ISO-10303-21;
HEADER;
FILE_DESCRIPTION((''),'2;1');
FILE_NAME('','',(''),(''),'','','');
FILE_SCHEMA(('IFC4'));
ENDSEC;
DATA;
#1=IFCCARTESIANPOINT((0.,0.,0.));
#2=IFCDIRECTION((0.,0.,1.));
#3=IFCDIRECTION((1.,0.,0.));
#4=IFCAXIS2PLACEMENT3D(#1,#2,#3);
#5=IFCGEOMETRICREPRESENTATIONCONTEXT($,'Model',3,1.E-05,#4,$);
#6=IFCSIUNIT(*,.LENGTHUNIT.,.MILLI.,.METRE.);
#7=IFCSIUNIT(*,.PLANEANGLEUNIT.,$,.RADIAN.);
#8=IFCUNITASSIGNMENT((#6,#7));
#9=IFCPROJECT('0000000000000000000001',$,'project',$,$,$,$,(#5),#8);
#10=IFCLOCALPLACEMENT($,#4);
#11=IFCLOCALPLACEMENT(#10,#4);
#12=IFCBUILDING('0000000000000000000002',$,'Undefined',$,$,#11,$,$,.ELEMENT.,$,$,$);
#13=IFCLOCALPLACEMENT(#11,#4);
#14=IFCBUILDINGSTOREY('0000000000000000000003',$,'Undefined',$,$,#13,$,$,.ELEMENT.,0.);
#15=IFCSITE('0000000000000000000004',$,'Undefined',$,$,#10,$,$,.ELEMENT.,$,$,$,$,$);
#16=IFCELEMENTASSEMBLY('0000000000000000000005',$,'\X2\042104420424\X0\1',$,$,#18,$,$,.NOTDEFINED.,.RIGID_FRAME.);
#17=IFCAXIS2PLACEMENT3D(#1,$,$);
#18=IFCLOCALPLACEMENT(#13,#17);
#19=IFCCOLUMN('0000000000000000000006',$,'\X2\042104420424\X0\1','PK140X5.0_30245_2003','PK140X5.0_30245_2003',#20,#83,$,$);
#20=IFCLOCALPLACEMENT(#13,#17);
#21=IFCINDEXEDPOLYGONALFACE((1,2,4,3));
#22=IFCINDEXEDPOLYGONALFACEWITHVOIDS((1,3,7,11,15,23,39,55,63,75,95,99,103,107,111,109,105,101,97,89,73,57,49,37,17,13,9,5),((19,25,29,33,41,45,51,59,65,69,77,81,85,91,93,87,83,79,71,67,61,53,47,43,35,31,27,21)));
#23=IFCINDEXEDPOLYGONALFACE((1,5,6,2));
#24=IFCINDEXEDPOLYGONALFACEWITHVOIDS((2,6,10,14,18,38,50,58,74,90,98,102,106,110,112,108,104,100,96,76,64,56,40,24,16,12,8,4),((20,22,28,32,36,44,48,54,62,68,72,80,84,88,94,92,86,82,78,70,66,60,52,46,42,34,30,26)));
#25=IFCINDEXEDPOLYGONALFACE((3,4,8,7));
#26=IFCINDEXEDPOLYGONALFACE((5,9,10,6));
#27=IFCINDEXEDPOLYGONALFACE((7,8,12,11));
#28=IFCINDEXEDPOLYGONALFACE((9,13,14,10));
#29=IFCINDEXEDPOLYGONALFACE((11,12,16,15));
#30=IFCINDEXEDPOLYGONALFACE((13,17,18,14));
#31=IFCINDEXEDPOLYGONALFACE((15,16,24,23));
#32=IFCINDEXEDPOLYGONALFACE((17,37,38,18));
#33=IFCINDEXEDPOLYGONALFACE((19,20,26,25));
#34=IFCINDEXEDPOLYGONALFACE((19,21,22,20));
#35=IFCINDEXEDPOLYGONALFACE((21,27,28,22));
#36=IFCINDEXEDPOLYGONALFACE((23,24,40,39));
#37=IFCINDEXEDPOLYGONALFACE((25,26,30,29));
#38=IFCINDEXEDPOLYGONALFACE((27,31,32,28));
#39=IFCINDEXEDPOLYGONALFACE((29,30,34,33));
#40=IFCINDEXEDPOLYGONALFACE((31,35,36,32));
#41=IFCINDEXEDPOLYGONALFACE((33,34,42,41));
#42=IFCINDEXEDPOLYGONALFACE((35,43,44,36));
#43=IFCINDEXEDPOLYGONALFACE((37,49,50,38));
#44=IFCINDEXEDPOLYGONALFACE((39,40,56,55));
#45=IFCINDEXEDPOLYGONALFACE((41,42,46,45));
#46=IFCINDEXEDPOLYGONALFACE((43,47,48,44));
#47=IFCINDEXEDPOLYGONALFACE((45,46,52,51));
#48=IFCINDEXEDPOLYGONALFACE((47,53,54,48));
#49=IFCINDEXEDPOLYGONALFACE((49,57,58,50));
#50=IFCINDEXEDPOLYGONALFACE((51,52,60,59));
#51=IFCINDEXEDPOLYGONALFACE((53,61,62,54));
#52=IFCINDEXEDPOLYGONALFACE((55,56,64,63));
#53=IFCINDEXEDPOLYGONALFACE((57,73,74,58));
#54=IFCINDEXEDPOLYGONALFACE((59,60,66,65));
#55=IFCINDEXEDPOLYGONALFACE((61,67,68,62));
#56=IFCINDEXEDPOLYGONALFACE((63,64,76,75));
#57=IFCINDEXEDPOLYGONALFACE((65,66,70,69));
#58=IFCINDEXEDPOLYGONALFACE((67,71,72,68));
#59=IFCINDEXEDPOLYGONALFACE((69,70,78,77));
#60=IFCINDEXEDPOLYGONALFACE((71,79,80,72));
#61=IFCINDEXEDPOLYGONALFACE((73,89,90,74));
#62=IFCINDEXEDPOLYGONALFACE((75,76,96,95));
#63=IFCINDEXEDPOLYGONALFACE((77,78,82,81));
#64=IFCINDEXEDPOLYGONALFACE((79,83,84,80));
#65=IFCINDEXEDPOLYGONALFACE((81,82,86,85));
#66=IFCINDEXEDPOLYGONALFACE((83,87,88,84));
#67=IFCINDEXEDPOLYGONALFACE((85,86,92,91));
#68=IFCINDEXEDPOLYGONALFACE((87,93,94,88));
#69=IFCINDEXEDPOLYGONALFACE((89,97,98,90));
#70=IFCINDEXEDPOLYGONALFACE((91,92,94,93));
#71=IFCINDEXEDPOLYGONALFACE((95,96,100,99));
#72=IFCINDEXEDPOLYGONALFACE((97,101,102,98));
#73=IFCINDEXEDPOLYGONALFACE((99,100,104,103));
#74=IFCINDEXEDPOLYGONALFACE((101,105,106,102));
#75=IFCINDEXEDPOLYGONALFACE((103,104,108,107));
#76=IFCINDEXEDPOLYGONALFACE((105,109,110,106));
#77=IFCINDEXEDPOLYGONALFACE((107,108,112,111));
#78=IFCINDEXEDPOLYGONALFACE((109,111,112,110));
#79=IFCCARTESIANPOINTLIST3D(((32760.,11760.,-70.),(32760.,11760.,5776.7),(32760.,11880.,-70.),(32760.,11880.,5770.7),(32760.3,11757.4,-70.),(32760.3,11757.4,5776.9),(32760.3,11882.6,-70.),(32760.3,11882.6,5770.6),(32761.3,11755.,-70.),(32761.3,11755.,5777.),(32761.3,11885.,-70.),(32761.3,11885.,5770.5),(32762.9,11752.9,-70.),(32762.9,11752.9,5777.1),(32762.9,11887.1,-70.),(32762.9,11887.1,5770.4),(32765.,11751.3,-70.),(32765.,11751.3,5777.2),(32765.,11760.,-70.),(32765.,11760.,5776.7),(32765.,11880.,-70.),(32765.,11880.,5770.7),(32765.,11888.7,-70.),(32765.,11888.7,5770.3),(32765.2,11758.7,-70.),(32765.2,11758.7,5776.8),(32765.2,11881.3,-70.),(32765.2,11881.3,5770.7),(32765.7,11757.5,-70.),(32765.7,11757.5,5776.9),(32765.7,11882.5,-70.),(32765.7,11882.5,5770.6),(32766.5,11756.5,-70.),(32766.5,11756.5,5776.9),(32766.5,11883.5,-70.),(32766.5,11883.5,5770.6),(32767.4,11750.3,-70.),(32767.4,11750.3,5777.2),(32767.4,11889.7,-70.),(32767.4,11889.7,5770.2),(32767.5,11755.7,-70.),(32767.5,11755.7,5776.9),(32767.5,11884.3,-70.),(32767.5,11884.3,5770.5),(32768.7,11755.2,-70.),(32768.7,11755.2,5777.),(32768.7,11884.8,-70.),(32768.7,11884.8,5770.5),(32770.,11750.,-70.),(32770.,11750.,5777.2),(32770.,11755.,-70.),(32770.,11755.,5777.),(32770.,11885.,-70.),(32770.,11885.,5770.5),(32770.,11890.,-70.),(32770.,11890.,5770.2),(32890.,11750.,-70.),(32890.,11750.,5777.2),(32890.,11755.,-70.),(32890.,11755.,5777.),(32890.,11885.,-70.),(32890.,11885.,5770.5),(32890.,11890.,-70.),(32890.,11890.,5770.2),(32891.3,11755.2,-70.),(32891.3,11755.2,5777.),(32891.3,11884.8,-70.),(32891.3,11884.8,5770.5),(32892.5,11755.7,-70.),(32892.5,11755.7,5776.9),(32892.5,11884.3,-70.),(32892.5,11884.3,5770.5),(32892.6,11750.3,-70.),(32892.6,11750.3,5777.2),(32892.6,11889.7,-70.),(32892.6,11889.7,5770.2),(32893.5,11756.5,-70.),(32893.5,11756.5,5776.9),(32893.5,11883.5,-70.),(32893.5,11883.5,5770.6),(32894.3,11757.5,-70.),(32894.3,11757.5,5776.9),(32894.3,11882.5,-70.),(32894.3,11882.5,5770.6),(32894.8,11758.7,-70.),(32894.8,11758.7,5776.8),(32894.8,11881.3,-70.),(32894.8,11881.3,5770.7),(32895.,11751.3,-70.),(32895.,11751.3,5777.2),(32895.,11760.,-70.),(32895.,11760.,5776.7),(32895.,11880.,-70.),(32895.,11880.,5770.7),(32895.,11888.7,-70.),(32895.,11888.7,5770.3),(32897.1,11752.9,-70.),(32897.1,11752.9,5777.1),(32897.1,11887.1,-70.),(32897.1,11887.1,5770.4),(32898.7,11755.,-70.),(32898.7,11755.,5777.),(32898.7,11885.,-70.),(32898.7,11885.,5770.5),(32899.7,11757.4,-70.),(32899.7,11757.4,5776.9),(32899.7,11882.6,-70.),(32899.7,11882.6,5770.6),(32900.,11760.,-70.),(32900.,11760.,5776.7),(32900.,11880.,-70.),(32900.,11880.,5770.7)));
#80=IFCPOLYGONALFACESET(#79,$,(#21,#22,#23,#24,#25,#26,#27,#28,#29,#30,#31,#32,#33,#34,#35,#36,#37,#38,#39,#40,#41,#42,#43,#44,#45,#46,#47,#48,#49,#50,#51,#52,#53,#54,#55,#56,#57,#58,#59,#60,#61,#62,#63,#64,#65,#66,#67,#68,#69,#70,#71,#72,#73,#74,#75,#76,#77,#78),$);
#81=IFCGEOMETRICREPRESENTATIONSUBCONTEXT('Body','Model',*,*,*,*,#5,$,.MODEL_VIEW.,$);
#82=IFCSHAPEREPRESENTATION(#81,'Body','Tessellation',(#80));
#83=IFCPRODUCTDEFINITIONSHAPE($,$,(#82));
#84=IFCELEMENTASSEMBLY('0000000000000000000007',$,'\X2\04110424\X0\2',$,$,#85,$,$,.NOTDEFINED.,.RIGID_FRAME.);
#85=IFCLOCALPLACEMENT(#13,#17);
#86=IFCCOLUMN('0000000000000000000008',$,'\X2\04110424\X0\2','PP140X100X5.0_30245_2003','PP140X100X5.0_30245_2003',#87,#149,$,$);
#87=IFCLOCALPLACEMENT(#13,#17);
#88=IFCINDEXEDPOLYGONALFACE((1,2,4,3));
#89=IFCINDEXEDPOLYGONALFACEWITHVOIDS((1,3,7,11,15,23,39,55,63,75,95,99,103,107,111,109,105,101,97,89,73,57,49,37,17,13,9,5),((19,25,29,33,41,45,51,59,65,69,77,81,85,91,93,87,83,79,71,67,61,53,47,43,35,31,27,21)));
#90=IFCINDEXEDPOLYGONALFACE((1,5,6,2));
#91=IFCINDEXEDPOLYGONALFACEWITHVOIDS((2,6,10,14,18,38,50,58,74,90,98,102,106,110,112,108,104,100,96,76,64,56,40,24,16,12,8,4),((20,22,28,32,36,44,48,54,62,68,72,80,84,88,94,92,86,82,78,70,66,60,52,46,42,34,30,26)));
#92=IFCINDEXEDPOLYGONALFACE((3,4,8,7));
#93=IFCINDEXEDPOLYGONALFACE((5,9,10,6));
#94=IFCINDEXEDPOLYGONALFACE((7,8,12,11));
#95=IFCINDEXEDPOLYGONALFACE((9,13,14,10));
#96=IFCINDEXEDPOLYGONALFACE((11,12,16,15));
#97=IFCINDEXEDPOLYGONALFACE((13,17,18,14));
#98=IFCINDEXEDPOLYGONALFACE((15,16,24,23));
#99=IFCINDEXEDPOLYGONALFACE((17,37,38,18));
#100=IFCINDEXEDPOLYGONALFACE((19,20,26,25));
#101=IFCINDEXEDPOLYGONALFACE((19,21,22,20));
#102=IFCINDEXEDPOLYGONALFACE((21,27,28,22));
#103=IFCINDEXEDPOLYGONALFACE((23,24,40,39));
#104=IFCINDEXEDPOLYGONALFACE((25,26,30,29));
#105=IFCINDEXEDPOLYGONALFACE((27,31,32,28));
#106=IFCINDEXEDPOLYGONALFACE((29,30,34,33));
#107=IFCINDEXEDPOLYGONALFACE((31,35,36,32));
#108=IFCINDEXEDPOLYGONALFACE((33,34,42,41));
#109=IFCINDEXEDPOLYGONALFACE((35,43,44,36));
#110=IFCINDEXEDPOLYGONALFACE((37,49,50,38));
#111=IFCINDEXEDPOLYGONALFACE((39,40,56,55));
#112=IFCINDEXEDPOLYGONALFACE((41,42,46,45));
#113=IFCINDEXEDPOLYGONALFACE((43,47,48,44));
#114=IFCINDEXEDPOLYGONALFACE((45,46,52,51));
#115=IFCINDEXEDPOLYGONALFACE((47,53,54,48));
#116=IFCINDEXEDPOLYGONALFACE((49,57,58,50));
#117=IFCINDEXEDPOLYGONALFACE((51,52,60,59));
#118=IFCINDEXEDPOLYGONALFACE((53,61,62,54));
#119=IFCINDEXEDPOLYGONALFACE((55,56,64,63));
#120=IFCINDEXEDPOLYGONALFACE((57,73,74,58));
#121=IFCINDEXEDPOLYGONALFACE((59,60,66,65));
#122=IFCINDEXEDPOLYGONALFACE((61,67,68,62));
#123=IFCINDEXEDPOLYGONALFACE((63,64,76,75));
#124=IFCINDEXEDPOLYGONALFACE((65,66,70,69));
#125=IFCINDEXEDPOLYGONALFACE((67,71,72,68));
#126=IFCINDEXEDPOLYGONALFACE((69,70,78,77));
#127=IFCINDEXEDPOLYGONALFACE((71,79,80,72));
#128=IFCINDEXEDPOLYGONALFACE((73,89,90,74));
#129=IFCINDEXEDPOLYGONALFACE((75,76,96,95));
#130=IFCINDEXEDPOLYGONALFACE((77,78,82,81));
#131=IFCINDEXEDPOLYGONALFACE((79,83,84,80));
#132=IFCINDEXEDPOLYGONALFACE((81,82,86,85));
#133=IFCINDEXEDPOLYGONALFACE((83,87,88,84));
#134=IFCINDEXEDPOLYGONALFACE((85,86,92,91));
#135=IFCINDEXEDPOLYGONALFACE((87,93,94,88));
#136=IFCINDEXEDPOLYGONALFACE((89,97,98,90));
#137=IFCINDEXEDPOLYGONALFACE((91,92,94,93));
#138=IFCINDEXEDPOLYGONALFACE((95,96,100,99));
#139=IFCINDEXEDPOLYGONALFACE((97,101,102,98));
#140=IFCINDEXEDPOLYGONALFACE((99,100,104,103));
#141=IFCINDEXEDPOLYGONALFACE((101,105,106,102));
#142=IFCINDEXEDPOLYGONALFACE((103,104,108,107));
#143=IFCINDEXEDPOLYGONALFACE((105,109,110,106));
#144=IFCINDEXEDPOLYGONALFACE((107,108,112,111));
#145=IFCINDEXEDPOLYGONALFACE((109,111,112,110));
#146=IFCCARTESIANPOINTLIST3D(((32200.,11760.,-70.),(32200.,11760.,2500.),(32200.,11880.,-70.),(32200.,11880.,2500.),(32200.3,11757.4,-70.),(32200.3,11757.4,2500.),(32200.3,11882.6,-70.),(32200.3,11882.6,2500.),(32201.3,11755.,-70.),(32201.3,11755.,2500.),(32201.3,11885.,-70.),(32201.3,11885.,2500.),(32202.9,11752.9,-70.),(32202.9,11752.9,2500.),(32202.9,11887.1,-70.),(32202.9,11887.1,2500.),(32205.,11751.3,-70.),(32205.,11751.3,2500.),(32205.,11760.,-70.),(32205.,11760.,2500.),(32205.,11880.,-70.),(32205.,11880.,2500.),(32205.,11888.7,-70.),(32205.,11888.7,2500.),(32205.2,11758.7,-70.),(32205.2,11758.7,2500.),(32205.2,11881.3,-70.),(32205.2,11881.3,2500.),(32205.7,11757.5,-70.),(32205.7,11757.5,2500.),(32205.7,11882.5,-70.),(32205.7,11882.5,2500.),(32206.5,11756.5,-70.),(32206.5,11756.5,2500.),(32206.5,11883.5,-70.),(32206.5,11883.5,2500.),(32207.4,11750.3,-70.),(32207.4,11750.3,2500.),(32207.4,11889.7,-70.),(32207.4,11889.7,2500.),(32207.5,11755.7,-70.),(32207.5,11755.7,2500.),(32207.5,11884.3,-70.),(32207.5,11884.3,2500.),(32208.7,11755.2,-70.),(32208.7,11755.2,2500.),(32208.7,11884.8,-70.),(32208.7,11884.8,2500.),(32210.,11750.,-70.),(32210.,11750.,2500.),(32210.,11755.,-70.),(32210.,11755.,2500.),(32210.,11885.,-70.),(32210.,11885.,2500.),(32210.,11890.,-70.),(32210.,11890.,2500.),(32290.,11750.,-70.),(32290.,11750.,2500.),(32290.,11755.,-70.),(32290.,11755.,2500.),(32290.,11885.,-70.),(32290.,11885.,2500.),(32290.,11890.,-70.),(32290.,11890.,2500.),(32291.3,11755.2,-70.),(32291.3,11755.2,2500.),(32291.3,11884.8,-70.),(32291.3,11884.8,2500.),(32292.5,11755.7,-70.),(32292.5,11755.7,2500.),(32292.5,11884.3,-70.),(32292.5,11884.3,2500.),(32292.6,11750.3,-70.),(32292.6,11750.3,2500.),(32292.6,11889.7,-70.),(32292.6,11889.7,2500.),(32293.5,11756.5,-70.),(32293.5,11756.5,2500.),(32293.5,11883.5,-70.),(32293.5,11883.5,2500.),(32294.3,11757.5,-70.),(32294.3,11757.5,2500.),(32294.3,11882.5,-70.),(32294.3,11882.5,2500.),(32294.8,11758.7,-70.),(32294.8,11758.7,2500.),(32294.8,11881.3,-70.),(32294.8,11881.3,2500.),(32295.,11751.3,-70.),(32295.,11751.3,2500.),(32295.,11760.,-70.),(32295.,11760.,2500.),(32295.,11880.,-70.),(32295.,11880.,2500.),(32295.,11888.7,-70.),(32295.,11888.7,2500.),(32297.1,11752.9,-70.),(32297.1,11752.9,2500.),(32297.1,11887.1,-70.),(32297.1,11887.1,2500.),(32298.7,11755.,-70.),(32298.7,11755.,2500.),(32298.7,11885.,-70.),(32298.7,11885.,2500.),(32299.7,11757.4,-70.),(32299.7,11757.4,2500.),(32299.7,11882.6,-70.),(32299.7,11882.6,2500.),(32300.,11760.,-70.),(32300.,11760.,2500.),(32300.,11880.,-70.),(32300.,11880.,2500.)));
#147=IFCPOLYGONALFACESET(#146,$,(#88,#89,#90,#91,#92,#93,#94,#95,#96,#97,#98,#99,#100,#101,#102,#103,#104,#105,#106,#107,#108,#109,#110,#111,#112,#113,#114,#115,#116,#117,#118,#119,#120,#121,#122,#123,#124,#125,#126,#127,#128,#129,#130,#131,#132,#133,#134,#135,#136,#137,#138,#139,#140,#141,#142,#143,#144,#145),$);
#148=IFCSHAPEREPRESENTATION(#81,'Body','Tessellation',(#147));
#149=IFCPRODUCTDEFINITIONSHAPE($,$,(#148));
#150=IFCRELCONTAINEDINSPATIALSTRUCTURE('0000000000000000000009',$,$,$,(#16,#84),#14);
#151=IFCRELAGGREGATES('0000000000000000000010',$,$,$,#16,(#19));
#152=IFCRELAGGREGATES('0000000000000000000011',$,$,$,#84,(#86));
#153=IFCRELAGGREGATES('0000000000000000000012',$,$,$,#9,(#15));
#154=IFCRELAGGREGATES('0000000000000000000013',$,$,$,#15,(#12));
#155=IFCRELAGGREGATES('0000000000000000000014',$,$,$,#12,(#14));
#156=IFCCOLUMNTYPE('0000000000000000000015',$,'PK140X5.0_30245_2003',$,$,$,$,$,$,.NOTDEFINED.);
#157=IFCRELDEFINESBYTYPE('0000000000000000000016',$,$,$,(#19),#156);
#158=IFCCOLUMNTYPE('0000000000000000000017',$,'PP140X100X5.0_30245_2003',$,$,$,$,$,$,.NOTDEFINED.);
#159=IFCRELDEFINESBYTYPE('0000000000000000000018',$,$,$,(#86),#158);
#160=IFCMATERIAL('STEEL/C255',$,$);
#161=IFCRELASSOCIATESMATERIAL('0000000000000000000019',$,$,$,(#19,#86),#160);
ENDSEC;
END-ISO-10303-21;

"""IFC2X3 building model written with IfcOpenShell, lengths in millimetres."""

from ifc_helpers import new_model, si_unit, frame, origin_with_axes, origin_2d_with_axis, place, context, subcontext, project, spatial, hollow_rectangle, extrude, clip, halfspace, material, type_object, element, aggregate, save


model = new_model("IFC2X3")

# Units and contexts
model_context = context("Model", 3, precision=1e-05, world=origin_with_axes())
body_context = subcontext(model_context, "Body", "Model", "MODEL_VIEW")
ifc_project = project(units=[si_unit("LENGTHUNIT", "METRE", prefix="MILLI"), si_unit("PLANEANGLEUNIT", "RADIAN")], contexts=[model_context])

# Site, building, storey
site_placement = place(None, origin_with_axes())
site = spatial("IfcSite", under=ifc_project, at=site_placement, Name="Undefined", CompositionType="ELEMENT")
building_placement = place(site_placement, origin_with_axes())
building = spatial("IfcBuilding", under=site, at=building_placement, Name="Undefined", CompositionType="ELEMENT")
storey_placement = place(building_placement, origin_with_axes())
storey = spatial("IfcBuildingStorey", under=building, at=storey_placement, Name="Undefined", CompositionType="ELEMENT", Elevation=0.0)

# Element assemblies, columns
ifc_material_1 = material(Name="STEEL/C255")
column_type_1 = type_object("IfcColumnType", Name="PK140X5.0_30245_2003", PredefinedType="NOTDEFINED")
assembly_1_placement = place(storey_placement, origin_with_axes())
assembly_1 = element("IfcElementAssembly", 1, at=assembly_1_placement, inside=storey, Name="СтФ1", AssemblyPlace="NOTDEFINED", PredefinedType="RIGID_FRAME")
column_1_placement = place(assembly_1_placement, frame((32830.0, 11820.0, -70.0), z_axis=(0.0, 0.0, 1.0), x_axis=(0.0, -1.0, 0.0)))
column_1 = element("IfcColumn", 2, at=column_1_placement, type_object=column_type_1, material=ifc_material_1, Name="СтФ1", Description="PK140X5.0_30245_2003", ObjectType="PK140X5.0_30245_2003", context=body_context, shape_type="Clipping", body=[
    clip(extrude(hollow_rectangle(XDim=140.0, YDim=140.0, WallThickness=5.0, InnerFilletRadius=5.0, OuterFilletRadius=10.0, at=origin_2d_with_axis()), frame((0.0, 0.0, 5920.0), z_axis=(0.0, 0.0, -1.0), x_axis=(0.0, 1.0, 0.0)), (0.0, 0.0, 1.0), 5920.0), halfspace(frame((-70.0, 70.0, 5840.2), z_axis=(-0.049938, 0.0, 0.998752), x_axis=(0.998752, 0.0, 0.049938)), False)),
])
aggregate(assembly_1, [column_1])
assembly_2_placement = place(storey_placement, origin_with_axes())
assembly_2 = element("IfcElementAssembly", 3, at=assembly_2_placement, inside=storey, Name="БФ2", AssemblyPlace="NOTDEFINED", PredefinedType="RIGID_FRAME")
column_type_2 = type_object("IfcColumnType", Name="PP140X100X5.0_30245_2003", PredefinedType="NOTDEFINED")
column_2_placement = place(assembly_2_placement, frame((32250.0, 11820.0, -70.0), z_axis=(0.0, 0.0, 1.0), x_axis=(0.0, -1.0, 0.0)))
column_2 = element("IfcColumn", 4, at=column_2_placement, type_object=column_type_2, material=ifc_material_1, Name="БФ2", Description="PP140X100X5.0_30245_2003", ObjectType="PP140X100X5.0_30245_2003", context=body_context, shape_type="SweptSolid", body=[
    extrude(hollow_rectangle(XDim=100.0, YDim=140.0, WallThickness=5.0, InnerFilletRadius=5.0, OuterFilletRadius=10.0, at=origin_2d_with_axis()), frame((0.0, 0.0, 2570.0), z_axis=(0.0, 0.0, -1.0), x_axis=(0.0, 1.0, 0.0)), (0.0, 0.0, 1.0), 2570.0),
])
aggregate(assembly_2, [column_2])

save(model, "model.ifc")
